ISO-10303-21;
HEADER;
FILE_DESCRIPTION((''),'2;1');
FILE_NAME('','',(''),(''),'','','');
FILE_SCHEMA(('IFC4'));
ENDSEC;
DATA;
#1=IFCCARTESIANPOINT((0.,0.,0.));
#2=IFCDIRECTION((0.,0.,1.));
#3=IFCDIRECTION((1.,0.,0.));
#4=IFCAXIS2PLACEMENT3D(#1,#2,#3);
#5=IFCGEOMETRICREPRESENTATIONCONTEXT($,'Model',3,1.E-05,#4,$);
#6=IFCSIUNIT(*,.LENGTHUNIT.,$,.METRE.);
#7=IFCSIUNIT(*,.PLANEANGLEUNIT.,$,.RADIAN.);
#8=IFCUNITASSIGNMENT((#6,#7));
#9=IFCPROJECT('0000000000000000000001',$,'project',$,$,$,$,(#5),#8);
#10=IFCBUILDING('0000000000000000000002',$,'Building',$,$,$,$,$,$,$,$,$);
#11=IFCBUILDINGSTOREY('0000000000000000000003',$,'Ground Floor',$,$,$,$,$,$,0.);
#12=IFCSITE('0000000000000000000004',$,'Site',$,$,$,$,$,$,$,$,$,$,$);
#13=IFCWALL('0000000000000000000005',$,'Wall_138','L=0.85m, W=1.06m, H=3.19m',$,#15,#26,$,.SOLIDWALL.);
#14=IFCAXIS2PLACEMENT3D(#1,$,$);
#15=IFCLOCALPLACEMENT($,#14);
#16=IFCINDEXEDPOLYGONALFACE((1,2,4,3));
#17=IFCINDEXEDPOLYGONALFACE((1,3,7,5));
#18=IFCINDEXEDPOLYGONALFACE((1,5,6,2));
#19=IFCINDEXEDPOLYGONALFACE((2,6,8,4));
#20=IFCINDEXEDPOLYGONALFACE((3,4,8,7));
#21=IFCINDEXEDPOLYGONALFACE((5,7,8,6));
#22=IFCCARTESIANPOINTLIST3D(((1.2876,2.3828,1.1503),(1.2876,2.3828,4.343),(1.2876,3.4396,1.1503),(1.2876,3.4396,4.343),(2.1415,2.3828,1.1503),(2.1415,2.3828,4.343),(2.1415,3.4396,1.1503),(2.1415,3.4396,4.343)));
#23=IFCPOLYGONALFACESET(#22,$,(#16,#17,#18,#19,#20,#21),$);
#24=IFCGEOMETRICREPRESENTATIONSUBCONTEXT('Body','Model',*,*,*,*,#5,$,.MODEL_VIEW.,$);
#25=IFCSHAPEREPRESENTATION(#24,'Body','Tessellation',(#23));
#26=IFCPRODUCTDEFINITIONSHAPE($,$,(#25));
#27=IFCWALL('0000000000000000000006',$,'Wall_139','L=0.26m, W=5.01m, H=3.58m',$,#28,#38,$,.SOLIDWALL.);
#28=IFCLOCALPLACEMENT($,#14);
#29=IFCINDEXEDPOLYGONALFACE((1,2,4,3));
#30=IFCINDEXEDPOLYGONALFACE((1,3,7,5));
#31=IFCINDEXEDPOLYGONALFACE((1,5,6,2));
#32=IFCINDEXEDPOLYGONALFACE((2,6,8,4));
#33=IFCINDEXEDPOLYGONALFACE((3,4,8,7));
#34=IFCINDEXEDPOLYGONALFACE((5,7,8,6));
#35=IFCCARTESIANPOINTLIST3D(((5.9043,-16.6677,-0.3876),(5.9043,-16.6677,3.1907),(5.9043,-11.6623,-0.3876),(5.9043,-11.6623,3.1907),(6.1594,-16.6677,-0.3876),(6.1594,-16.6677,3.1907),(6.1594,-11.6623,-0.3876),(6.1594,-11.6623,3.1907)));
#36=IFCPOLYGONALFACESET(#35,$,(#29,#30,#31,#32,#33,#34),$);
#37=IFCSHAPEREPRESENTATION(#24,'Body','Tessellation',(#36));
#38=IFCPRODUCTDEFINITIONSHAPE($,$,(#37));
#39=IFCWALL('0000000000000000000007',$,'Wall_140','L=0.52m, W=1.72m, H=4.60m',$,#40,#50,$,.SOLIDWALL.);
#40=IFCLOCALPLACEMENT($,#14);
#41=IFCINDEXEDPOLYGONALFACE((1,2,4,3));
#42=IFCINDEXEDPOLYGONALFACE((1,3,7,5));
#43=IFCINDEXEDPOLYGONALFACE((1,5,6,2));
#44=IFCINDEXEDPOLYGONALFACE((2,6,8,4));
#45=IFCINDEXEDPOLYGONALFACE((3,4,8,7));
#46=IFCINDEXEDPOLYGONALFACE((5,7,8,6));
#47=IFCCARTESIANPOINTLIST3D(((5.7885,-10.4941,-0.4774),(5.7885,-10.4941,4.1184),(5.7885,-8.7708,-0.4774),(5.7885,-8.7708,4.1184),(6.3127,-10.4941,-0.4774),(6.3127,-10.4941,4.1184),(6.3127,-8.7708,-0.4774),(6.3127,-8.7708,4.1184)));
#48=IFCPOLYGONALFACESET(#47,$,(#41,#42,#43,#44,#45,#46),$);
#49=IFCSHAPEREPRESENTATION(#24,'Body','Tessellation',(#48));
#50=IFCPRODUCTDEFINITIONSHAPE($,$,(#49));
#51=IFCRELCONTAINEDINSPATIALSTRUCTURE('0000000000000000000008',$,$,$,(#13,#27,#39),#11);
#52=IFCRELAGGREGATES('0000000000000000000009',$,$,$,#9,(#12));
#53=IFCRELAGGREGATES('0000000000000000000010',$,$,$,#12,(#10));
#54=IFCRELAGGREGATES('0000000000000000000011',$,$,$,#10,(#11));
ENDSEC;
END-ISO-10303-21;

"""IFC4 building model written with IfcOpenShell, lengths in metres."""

from ifc_helpers import new_model, si_unit, frame, origin_with_axes, origin_2d, context, subcontext, project, spatial, rectangle, extrude, element, save


model = new_model("IFC4")

# Units and contexts
model_context = context("Model", 3, precision=1e-05, world=origin_with_axes())
body_context = subcontext(model_context, "Body", "Model", "MODEL_VIEW")
ifc_project = project(units=[si_unit("LENGTHUNIT", "METRE"), si_unit("PLANEANGLEUNIT", "RADIAN")], contexts=[model_context])

# Site, building, storey
site = spatial("IfcSite", under=ifc_project, Name="Site")
building = spatial("IfcBuilding", under=site, Name="Building")
storey = spatial("IfcBuildingStorey", under=building, Name="Ground Floor", Elevation=0.0)

# Walls
element("IfcWall", 1, inside=storey, Name="Wall_138", Description="L=0.85m, W=1.06m, H=3.19m", PredefinedType="SOLIDWALL", context=body_context, shape_type="SweptSolid", body=[
    extrude(rectangle(XDim=0.8539, YDim=1.0568, at=origin_2d()), frame((1.7145, 2.9112, 1.1503), z_axis=(0.0, 0.0, 1.0), x_axis=(1.0, 0.0, 0.0)), (0.0, 0.0, 1.0), 3.1927),
])
element("IfcWall", 2, inside=storey, Name="Wall_139", Description="L=0.26m, W=5.01m, H=3.58m", PredefinedType="SOLIDWALL", context=body_context, shape_type="SweptSolid", body=[
    extrude(rectangle(XDim=0.255, YDim=5.0054, at=origin_2d()), frame((6.0319, -14.165, -0.3876), z_axis=(0.0, 0.0, 1.0), x_axis=(1.0, 0.0, 0.0)), (0.0, 0.0, 1.0), 3.5783),
])
element("IfcWall", 3, inside=storey, Name="Wall_140", Description="L=0.52m, W=1.72m, H=4.60m", PredefinedType="SOLIDWALL", context=body_context, shape_type="SweptSolid", body=[
    extrude(rectangle(XDim=0.5242, YDim=1.7233, at=origin_2d()), frame((6.0506, -9.6325, -0.4774), z_axis=(0.0, 0.0, 1.0), x_axis=(1.0, 0.0, 0.0)), (0.0, 0.0, 1.0), 4.5957),
])

save(model, "model.ifc")
